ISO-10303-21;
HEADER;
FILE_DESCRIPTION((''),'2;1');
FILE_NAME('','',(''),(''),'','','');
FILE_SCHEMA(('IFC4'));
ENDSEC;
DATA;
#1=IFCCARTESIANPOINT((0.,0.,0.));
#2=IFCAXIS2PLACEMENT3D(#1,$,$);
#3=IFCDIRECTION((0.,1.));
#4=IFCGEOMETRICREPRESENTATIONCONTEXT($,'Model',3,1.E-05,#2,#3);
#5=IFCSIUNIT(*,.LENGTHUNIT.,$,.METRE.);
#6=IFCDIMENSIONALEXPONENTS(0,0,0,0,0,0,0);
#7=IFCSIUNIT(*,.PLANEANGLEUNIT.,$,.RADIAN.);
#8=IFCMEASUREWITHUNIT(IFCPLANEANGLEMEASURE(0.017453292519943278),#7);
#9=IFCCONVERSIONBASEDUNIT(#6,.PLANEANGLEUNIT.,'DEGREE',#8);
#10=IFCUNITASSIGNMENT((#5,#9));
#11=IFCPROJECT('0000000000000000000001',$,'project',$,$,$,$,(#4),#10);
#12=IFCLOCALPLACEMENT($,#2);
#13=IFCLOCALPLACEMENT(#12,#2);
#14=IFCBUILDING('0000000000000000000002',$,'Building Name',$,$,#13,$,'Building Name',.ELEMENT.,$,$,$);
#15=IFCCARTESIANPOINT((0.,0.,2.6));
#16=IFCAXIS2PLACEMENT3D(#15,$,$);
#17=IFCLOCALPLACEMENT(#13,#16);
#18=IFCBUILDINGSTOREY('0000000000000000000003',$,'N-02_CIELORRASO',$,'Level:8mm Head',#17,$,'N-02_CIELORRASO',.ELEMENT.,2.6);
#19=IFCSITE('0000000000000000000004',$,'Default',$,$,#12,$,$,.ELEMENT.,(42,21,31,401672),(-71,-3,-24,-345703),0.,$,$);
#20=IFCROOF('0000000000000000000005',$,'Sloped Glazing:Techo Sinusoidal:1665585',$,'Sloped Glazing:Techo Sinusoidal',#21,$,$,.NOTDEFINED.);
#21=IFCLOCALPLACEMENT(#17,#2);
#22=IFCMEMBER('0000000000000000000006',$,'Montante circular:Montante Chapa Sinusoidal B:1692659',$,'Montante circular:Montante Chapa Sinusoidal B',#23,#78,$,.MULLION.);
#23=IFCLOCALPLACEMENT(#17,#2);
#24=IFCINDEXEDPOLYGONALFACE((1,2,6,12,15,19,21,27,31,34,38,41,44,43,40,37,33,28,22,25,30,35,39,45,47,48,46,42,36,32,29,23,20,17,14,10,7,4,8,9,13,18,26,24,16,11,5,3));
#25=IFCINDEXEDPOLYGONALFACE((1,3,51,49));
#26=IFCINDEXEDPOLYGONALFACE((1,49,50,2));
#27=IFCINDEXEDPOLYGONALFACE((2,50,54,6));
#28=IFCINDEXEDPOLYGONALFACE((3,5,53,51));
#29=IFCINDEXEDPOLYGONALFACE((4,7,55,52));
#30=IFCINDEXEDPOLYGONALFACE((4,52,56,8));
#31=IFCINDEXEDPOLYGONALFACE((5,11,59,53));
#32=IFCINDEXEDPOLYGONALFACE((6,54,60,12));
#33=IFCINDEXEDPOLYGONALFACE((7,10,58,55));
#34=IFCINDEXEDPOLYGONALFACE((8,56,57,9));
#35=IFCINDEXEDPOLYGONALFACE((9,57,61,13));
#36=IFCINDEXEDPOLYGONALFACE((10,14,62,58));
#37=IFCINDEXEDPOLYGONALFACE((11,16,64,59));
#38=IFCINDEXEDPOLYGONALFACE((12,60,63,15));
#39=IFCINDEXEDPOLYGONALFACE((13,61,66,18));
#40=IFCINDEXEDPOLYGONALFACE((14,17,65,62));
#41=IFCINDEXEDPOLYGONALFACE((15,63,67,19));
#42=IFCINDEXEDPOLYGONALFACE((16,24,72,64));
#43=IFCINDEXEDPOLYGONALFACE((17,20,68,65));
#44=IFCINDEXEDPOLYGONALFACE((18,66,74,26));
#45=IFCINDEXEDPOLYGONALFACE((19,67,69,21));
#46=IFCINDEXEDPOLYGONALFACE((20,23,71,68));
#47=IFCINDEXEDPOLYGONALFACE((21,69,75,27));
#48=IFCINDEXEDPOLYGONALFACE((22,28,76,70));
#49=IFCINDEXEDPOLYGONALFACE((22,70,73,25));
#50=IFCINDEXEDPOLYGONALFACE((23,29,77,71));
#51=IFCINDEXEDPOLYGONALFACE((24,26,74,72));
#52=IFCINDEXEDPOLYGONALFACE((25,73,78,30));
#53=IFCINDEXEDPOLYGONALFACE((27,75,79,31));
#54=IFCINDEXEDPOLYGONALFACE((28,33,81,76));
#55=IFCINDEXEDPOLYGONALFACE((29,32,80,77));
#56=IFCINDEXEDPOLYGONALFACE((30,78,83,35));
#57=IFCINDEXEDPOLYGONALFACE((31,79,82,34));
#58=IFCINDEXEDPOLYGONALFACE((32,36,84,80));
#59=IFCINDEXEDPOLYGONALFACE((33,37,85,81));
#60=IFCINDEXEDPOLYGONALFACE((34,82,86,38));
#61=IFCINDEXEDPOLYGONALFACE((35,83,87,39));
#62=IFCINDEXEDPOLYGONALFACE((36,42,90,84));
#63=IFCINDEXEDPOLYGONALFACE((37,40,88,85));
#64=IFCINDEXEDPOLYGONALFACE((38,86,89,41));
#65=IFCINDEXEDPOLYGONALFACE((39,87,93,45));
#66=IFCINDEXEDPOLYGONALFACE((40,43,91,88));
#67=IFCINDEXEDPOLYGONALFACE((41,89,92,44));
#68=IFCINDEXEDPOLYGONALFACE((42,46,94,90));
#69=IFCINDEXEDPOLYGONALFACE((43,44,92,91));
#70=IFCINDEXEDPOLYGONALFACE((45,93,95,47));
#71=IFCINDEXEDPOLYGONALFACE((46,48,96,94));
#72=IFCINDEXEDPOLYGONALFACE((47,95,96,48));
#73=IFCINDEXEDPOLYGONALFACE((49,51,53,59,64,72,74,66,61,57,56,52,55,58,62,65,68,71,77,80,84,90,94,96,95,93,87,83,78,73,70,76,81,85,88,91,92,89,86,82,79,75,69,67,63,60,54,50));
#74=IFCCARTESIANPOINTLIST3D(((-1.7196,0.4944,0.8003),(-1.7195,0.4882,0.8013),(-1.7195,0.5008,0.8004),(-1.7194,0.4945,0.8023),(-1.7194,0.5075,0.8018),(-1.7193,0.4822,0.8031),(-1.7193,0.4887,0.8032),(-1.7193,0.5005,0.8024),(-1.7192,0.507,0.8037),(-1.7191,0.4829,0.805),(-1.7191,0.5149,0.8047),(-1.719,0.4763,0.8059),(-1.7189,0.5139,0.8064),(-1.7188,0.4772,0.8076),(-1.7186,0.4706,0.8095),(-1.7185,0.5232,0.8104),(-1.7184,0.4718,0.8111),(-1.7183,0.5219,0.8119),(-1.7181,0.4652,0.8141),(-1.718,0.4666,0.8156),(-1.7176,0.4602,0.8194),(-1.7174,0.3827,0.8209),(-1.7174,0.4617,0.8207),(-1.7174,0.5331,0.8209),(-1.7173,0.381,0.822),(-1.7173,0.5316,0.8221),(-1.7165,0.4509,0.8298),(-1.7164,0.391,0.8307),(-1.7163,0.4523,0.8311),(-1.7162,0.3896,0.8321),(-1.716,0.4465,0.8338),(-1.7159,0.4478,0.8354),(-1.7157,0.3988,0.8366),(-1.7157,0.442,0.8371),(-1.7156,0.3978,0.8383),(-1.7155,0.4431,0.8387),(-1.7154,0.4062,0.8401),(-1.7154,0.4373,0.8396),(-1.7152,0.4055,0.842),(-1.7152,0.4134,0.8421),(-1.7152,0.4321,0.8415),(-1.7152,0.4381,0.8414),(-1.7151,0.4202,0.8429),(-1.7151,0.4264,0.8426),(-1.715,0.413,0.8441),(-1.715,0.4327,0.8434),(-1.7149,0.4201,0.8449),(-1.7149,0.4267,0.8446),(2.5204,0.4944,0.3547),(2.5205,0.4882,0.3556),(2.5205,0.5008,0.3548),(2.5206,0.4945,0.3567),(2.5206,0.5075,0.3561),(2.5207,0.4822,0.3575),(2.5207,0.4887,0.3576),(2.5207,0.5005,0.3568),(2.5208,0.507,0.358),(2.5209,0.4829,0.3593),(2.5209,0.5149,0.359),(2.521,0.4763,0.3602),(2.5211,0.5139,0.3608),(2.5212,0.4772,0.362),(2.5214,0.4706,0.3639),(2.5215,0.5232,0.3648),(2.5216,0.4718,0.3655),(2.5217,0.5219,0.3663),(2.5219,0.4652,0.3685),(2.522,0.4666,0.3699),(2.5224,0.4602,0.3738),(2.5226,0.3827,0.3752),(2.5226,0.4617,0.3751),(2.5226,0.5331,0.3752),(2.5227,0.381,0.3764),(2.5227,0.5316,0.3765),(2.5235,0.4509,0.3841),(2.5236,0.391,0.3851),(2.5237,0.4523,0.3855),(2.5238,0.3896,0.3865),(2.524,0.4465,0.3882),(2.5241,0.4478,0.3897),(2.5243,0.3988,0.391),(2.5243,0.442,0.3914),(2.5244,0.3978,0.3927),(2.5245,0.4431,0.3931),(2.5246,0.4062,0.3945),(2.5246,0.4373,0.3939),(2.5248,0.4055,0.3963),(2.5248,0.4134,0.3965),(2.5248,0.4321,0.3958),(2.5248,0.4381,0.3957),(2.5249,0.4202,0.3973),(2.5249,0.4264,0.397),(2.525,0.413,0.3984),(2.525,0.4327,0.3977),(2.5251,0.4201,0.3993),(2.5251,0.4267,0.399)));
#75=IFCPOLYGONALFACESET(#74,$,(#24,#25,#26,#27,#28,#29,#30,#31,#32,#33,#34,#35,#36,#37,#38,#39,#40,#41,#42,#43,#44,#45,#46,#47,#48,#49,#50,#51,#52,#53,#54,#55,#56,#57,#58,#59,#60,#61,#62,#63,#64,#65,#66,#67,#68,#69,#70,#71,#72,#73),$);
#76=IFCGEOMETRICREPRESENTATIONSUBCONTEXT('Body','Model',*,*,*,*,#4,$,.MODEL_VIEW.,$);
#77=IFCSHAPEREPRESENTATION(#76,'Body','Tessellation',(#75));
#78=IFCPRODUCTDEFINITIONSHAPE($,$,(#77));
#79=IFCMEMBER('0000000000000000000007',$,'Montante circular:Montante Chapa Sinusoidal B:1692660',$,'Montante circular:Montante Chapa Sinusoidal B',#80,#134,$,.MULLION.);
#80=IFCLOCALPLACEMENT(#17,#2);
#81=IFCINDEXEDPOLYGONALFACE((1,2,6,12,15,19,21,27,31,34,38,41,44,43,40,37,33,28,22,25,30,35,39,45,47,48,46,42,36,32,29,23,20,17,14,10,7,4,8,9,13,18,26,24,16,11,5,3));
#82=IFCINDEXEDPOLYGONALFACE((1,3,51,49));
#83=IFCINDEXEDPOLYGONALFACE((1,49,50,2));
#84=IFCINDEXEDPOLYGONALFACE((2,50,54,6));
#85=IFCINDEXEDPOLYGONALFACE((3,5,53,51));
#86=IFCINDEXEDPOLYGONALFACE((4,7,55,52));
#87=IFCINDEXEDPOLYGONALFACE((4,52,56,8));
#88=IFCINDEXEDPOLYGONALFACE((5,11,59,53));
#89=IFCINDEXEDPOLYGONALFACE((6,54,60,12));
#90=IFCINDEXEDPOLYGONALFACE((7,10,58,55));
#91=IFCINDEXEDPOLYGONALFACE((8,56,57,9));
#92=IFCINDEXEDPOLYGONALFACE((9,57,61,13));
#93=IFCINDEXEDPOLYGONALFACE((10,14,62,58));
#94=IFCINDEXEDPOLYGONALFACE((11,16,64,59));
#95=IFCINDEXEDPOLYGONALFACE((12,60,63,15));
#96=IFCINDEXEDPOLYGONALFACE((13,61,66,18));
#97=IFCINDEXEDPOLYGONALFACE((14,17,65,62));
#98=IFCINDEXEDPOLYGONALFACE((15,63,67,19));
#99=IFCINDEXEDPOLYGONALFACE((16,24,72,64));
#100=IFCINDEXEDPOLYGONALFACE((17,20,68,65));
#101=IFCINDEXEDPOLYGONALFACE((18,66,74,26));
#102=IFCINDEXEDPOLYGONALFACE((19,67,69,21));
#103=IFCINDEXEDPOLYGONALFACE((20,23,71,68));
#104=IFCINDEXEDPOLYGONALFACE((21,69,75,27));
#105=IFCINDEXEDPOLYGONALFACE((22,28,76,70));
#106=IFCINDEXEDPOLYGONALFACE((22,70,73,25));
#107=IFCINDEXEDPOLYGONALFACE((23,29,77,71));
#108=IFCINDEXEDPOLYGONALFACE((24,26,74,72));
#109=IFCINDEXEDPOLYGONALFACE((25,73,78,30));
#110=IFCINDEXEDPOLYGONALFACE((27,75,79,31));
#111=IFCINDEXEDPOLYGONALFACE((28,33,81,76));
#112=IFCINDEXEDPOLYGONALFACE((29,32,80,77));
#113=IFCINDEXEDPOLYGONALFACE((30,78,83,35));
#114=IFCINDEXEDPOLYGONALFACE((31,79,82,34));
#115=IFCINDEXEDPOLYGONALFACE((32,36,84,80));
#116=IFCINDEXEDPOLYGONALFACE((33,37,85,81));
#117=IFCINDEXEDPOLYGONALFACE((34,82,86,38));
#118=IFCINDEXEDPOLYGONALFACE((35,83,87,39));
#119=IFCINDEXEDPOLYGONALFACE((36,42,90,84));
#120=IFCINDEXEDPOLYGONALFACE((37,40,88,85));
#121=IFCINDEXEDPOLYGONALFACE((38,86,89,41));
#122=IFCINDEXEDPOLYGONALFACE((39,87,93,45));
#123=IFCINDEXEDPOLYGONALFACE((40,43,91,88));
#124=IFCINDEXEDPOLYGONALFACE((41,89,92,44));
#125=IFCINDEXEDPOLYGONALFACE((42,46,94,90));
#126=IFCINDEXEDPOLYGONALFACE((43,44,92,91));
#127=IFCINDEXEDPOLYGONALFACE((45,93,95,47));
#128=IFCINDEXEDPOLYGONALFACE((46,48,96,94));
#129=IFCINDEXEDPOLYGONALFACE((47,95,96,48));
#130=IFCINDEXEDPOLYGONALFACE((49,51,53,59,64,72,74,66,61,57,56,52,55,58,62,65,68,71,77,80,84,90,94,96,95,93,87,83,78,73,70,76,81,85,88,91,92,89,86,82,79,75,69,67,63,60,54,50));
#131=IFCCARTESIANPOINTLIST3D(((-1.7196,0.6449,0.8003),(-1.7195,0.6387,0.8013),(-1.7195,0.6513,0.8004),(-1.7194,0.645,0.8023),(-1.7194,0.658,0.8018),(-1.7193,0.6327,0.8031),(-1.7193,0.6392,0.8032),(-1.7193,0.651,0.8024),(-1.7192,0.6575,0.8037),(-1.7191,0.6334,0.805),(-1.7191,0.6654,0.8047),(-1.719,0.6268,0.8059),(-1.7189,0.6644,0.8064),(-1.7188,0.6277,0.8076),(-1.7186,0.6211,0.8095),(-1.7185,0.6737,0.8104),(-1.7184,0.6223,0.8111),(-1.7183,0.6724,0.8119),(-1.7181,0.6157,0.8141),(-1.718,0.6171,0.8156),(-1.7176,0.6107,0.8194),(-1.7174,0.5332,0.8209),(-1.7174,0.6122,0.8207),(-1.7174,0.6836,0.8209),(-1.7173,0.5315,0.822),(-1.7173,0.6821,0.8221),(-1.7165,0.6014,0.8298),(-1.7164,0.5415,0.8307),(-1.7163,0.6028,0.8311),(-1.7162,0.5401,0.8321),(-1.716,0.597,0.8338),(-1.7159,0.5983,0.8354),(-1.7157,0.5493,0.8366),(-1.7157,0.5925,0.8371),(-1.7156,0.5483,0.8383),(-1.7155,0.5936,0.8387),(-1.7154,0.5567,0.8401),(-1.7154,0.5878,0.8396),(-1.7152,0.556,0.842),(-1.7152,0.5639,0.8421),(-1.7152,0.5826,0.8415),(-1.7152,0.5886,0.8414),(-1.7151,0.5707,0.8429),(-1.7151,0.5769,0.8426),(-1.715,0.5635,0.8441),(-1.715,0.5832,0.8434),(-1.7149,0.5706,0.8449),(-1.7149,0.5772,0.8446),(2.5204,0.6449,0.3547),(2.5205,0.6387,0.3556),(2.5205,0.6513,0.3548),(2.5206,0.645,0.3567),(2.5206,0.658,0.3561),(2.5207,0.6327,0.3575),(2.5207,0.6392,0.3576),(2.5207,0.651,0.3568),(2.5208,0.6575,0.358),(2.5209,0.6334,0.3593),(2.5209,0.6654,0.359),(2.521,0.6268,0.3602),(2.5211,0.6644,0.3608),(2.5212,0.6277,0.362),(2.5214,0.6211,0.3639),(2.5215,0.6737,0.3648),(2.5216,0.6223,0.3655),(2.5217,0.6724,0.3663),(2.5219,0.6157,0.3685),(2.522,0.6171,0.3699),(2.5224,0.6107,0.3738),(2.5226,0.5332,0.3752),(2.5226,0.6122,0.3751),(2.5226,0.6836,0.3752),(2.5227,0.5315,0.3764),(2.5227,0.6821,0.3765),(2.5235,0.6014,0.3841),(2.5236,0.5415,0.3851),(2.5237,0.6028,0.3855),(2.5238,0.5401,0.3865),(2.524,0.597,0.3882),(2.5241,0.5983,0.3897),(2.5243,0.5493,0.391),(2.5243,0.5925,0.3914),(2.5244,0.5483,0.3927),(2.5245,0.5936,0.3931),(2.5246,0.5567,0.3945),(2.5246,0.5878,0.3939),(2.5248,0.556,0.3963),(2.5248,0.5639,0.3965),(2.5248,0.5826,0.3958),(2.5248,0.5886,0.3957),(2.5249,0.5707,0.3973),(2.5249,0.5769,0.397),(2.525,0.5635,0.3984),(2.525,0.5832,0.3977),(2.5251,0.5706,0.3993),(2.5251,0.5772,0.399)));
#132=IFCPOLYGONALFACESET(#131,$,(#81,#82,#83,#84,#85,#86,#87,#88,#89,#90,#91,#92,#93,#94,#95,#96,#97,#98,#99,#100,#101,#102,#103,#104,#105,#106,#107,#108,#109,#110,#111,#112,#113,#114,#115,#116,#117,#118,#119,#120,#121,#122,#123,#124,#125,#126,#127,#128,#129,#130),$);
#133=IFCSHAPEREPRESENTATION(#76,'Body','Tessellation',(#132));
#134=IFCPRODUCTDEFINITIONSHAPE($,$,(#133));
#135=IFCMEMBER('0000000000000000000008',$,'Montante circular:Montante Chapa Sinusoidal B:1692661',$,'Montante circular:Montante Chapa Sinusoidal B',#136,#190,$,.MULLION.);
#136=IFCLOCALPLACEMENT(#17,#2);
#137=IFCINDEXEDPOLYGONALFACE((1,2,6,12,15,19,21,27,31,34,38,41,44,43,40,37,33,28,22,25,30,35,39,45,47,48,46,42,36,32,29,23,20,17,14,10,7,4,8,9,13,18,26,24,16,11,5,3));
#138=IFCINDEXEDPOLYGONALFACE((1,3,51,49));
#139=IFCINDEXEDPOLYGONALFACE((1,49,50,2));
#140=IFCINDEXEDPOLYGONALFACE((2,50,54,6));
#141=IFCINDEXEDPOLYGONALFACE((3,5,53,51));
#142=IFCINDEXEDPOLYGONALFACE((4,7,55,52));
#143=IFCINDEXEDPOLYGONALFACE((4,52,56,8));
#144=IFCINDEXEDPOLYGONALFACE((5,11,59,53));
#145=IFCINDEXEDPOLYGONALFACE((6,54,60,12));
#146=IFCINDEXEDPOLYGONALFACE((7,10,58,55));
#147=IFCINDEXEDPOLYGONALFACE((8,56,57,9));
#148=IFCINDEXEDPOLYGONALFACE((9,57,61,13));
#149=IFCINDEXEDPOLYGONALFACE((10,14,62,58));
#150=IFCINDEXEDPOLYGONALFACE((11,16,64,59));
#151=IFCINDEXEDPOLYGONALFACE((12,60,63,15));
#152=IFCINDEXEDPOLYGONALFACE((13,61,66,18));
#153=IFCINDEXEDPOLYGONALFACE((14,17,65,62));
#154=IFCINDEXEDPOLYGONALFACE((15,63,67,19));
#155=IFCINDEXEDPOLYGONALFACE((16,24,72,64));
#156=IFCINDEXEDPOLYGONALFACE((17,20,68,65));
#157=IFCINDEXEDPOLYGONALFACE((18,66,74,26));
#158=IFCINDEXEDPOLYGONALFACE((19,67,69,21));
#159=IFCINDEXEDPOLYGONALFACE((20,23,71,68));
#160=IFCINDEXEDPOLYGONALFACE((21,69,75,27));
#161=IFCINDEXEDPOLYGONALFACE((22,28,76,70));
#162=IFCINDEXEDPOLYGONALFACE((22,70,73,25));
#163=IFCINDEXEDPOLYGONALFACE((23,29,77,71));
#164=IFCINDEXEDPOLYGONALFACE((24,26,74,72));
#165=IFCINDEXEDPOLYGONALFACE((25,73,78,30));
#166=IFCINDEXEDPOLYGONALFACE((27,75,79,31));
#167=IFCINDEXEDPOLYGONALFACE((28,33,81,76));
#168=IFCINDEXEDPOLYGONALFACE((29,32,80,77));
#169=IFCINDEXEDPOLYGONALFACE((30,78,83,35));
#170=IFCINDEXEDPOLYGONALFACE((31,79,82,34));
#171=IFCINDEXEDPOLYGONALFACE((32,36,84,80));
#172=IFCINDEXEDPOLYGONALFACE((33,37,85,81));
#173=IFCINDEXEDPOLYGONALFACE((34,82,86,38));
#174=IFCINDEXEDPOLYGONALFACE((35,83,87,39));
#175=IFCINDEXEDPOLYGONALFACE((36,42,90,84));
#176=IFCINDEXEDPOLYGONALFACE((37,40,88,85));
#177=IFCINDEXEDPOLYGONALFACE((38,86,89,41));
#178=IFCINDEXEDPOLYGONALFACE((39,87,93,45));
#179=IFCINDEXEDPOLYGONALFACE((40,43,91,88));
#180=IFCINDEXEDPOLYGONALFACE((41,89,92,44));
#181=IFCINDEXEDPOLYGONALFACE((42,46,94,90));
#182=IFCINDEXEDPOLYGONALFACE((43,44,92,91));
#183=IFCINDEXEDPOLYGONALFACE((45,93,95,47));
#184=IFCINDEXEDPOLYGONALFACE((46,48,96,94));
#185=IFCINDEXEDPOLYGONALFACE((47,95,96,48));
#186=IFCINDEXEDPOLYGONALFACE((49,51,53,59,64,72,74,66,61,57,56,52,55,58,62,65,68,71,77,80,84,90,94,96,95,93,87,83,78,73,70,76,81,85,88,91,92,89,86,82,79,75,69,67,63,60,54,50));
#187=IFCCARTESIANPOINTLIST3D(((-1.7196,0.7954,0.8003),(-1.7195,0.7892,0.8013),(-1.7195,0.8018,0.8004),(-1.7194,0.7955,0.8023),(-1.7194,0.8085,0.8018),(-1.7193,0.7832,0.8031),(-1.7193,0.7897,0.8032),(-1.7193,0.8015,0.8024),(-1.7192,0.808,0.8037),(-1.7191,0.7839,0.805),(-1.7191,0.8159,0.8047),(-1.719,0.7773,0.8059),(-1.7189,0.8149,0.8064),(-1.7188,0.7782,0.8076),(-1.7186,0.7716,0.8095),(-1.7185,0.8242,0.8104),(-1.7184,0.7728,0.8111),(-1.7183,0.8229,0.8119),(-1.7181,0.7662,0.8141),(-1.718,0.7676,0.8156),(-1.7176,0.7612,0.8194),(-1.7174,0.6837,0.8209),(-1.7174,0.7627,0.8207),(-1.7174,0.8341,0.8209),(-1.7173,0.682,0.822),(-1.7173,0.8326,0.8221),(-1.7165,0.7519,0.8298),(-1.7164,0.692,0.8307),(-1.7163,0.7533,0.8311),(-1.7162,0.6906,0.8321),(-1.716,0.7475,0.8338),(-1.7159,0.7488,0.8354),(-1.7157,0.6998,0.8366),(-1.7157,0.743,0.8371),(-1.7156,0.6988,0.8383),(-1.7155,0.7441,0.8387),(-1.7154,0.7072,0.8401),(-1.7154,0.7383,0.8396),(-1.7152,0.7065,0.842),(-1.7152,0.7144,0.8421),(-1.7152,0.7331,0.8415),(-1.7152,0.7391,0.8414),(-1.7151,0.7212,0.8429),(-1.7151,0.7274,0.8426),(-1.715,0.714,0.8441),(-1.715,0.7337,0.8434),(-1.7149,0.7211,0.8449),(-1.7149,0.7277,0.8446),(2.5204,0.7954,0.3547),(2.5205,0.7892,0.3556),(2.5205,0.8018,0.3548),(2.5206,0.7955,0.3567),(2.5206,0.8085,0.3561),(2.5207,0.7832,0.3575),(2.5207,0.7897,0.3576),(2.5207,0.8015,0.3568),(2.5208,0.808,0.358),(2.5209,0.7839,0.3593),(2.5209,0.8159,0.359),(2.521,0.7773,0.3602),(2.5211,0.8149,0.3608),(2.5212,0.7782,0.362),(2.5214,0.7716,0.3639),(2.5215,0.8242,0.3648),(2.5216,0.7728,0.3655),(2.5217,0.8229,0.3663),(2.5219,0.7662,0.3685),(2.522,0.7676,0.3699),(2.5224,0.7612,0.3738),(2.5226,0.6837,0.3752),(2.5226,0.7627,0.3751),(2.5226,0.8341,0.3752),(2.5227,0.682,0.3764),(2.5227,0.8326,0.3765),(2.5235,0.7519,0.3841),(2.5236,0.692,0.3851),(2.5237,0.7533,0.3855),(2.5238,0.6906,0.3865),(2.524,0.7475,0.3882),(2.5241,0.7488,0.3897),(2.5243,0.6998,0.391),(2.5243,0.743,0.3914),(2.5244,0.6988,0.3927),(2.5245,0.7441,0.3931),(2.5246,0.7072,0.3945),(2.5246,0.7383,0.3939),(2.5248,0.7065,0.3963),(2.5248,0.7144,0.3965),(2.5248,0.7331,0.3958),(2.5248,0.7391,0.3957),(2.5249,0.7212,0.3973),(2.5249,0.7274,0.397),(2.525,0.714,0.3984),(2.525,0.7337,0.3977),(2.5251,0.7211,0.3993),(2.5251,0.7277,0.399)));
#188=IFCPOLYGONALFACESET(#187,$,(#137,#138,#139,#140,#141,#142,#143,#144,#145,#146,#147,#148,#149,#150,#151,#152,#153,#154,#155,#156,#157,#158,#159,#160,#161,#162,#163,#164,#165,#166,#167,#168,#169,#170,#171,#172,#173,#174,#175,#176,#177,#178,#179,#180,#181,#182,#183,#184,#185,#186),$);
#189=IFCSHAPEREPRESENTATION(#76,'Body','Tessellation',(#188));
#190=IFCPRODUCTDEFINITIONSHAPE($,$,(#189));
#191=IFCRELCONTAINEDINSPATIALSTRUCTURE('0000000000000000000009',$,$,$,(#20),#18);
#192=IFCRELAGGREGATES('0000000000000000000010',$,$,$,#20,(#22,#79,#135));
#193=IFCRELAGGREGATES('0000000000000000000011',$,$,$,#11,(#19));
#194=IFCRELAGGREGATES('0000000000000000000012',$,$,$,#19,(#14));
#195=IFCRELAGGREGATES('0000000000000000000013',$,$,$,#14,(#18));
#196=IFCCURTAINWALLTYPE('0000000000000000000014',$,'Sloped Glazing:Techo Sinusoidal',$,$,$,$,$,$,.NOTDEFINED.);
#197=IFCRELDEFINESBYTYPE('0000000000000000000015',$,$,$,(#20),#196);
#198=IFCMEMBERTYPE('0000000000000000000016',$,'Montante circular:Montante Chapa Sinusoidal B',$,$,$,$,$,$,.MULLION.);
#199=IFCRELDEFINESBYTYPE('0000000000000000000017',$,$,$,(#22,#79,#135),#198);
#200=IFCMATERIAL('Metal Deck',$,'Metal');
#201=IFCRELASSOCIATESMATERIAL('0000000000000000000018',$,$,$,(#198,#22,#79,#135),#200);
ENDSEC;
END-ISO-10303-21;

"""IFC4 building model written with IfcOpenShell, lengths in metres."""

from ifc_helpers import new_model, entity, si_unit, converted_unit, direction, frame, origin, place, context, subcontext, project, spatial, indexed_curve, outline, extrude, source, transform, mapped, material, type_object, type_shapes, element, aggregate, save


model = new_model("IFC4")

# Units and contexts
model_context = context("Model", 3, precision=1e-05, world=origin(), true_north=direction((0.0, 1.0)))
body_context = subcontext(model_context, "Body", "Model", "MODEL_VIEW")
ifc_project = project(units=[si_unit("LENGTHUNIT", "METRE"), converted_unit("PLANEANGLEUNIT", "DEGREE", entity("IfcPlaneAngleMeasure", 0.017453292519943278), si_unit("PLANEANGLEUNIT", "RADIAN"), dimensions=[0, 0, 0, 0, 0, 0, 0])], contexts=[model_context])

# Site, building, storey
site_placement = place(None, origin())
site = spatial("IfcSite", under=ifc_project, at=site_placement, Name="Default", CompositionType="ELEMENT", RefLatitude=(42, 21, 31, 401672), RefLongitude=(-71, -3, -24, -345703), RefElevation=0.0)
building_placement = place(site_placement, origin())
building = spatial("IfcBuilding", under=site, at=building_placement, Name="Building Name", LongName="Building Name", CompositionType="ELEMENT")
storey_placement = place(building_placement, frame((0.0, 0.0, 2.6)))
storey = spatial("IfcBuildingStorey", under=building, at=storey_placement, Name="N-02_CIELORRASO", ObjectType="Level:8mm Head", LongName="N-02_CIELORRASO", CompositionType="ELEMENT", Elevation=2.6)

# Roof, members
curtain_wall_type = type_object("IfcCurtainWallType", Name="Sloped Glazing:Techo Sinusoidal", PredefinedType="NOTDEFINED")
roof_placement = place(storey_placement, frame((0.0, 0.0, -2.6)))
roof = element("IfcRoof", 1, at=roof_placement, inside=storey, type_object=curtain_wall_type, Name="Sloped Glazing:Techo Sinusoidal:1665585", ObjectType="Sloped Glazing:Techo Sinusoidal", PredefinedType="NOTDEFINED")
ifc_material = material(Name="Metal Deck", Category="Metal")
member_type = type_object("IfcMemberType", Name="Montante circular:Montante Chapa Sinusoidal B", PredefinedType="MULLION", material=ifc_material)
shared_shape = source(origin(), body_context, "Body", "SweptSolid", [
    extrude(outline(indexed_curve([(0.0595, -0.0443), (0.0615, -0.0443), (0.0603, -0.031), (0.0572, -0.0213), (0.053, -0.0138), (0.0481, -0.0078), (0.0427, -0.003), (0.0372, 0.0005), (0.0315, 0.0029), (0.0259, 0.0044), (0.0203, 0.0051), (0.0146, 0.005), (0.0084, 0.0041), (-0.0053, 0.0009), (-0.0123, -0.0005), (-0.0191, -0.0012), (-0.0256, -0.001), (-0.0317, 0.0001), (-0.0375, 0.0019), (-0.0428, 0.0046), (-0.0477, 0.0081), (-0.0522, 0.0128), (-0.0563, 0.0191), (-0.0597, 0.0282), (-0.0617, 0.0421), (-0.0637, 0.042), (-0.0616, 0.0277), (-0.0581, 0.0182), (-0.0537, 0.0116), (-0.049, 0.0066), (-0.0438, 0.0028), (-0.0382, 0.0001), (-0.0322, -0.0019), (-0.0258, -0.003), (-0.019, -0.0032), (-0.012, -0.0025), (-0.0048, -0.0011), (0.0088, 0.0021), (0.0147, 0.003), (0.0202, 0.0031), (0.0255, 0.0024), (0.0309, 0.001), (0.0362, -0.0013), (0.0415, -0.0046), (0.0466, -0.0092), (0.0513, -0.0149), (0.0554, -0.0221), (0.0584, -0.0314), (0.0595, -0.0443)], self_intersect=False)), frame((-0.007, 0.0228, -4.2634), z_axis=(0.0, 0.0, 1.0), x_axis=(-0.819152, -0.573576, 0.0)), (0.0, 0.0, 1.0), 4.2634),
])
type_shapes(member_type, [shared_shape])
member_1_placement = place(roof_placement, frame((-1.7148, 0.4639, 3.4456), z_axis=(-0.994522, 0.0, 0.104528), x_axis=(0.0, 1.0, 0.0)))
member_1 = element("IfcMember", 2, at=member_1_placement, type_object=member_type, material=ifc_material, Name="Montante circular:Montante Chapa Sinusoidal B:1692659", ObjectType="Montante circular:Montante Chapa Sinusoidal B", PredefinedType="MULLION", context=body_context, shape_type="MappedRepresentation", body=[
    mapped(shared_shape, transform((0.0, 0.0, 0.0), scale=1.0)),
])
member_2_placement = place(roof_placement, frame((-1.7148, 0.6144, 3.4456), z_axis=(-0.994522, 0.0, 0.104528), x_axis=(0.0, 1.0, 0.0)))
member_2 = element("IfcMember", 3, at=member_2_placement, type_object=member_type, material=ifc_material, Name="Montante circular:Montante Chapa Sinusoidal B:1692660", ObjectType="Montante circular:Montante Chapa Sinusoidal B", PredefinedType="MULLION", context=body_context, shape_type="MappedRepresentation", body=[
    mapped(shared_shape, transform((0.0, 0.0, 0.0), scale=1.0)),
])
member_3_placement = place(roof_placement, frame((-1.7148, 0.7649, 3.4456), z_axis=(-0.994522, 0.0, 0.104528), x_axis=(0.0, 1.0, 0.0)))
member_3 = element("IfcMember", 4, at=member_3_placement, type_object=member_type, material=ifc_material, Name="Montante circular:Montante Chapa Sinusoidal B:1692661", ObjectType="Montante circular:Montante Chapa Sinusoidal B", PredefinedType="MULLION", context=body_context, shape_type="MappedRepresentation", body=[
    mapped(shared_shape, transform((0.0, 0.0, 0.0), scale=1.0)),
])
aggregate(roof, [member_1, member_2, member_3])

save(model, "model.ifc")
